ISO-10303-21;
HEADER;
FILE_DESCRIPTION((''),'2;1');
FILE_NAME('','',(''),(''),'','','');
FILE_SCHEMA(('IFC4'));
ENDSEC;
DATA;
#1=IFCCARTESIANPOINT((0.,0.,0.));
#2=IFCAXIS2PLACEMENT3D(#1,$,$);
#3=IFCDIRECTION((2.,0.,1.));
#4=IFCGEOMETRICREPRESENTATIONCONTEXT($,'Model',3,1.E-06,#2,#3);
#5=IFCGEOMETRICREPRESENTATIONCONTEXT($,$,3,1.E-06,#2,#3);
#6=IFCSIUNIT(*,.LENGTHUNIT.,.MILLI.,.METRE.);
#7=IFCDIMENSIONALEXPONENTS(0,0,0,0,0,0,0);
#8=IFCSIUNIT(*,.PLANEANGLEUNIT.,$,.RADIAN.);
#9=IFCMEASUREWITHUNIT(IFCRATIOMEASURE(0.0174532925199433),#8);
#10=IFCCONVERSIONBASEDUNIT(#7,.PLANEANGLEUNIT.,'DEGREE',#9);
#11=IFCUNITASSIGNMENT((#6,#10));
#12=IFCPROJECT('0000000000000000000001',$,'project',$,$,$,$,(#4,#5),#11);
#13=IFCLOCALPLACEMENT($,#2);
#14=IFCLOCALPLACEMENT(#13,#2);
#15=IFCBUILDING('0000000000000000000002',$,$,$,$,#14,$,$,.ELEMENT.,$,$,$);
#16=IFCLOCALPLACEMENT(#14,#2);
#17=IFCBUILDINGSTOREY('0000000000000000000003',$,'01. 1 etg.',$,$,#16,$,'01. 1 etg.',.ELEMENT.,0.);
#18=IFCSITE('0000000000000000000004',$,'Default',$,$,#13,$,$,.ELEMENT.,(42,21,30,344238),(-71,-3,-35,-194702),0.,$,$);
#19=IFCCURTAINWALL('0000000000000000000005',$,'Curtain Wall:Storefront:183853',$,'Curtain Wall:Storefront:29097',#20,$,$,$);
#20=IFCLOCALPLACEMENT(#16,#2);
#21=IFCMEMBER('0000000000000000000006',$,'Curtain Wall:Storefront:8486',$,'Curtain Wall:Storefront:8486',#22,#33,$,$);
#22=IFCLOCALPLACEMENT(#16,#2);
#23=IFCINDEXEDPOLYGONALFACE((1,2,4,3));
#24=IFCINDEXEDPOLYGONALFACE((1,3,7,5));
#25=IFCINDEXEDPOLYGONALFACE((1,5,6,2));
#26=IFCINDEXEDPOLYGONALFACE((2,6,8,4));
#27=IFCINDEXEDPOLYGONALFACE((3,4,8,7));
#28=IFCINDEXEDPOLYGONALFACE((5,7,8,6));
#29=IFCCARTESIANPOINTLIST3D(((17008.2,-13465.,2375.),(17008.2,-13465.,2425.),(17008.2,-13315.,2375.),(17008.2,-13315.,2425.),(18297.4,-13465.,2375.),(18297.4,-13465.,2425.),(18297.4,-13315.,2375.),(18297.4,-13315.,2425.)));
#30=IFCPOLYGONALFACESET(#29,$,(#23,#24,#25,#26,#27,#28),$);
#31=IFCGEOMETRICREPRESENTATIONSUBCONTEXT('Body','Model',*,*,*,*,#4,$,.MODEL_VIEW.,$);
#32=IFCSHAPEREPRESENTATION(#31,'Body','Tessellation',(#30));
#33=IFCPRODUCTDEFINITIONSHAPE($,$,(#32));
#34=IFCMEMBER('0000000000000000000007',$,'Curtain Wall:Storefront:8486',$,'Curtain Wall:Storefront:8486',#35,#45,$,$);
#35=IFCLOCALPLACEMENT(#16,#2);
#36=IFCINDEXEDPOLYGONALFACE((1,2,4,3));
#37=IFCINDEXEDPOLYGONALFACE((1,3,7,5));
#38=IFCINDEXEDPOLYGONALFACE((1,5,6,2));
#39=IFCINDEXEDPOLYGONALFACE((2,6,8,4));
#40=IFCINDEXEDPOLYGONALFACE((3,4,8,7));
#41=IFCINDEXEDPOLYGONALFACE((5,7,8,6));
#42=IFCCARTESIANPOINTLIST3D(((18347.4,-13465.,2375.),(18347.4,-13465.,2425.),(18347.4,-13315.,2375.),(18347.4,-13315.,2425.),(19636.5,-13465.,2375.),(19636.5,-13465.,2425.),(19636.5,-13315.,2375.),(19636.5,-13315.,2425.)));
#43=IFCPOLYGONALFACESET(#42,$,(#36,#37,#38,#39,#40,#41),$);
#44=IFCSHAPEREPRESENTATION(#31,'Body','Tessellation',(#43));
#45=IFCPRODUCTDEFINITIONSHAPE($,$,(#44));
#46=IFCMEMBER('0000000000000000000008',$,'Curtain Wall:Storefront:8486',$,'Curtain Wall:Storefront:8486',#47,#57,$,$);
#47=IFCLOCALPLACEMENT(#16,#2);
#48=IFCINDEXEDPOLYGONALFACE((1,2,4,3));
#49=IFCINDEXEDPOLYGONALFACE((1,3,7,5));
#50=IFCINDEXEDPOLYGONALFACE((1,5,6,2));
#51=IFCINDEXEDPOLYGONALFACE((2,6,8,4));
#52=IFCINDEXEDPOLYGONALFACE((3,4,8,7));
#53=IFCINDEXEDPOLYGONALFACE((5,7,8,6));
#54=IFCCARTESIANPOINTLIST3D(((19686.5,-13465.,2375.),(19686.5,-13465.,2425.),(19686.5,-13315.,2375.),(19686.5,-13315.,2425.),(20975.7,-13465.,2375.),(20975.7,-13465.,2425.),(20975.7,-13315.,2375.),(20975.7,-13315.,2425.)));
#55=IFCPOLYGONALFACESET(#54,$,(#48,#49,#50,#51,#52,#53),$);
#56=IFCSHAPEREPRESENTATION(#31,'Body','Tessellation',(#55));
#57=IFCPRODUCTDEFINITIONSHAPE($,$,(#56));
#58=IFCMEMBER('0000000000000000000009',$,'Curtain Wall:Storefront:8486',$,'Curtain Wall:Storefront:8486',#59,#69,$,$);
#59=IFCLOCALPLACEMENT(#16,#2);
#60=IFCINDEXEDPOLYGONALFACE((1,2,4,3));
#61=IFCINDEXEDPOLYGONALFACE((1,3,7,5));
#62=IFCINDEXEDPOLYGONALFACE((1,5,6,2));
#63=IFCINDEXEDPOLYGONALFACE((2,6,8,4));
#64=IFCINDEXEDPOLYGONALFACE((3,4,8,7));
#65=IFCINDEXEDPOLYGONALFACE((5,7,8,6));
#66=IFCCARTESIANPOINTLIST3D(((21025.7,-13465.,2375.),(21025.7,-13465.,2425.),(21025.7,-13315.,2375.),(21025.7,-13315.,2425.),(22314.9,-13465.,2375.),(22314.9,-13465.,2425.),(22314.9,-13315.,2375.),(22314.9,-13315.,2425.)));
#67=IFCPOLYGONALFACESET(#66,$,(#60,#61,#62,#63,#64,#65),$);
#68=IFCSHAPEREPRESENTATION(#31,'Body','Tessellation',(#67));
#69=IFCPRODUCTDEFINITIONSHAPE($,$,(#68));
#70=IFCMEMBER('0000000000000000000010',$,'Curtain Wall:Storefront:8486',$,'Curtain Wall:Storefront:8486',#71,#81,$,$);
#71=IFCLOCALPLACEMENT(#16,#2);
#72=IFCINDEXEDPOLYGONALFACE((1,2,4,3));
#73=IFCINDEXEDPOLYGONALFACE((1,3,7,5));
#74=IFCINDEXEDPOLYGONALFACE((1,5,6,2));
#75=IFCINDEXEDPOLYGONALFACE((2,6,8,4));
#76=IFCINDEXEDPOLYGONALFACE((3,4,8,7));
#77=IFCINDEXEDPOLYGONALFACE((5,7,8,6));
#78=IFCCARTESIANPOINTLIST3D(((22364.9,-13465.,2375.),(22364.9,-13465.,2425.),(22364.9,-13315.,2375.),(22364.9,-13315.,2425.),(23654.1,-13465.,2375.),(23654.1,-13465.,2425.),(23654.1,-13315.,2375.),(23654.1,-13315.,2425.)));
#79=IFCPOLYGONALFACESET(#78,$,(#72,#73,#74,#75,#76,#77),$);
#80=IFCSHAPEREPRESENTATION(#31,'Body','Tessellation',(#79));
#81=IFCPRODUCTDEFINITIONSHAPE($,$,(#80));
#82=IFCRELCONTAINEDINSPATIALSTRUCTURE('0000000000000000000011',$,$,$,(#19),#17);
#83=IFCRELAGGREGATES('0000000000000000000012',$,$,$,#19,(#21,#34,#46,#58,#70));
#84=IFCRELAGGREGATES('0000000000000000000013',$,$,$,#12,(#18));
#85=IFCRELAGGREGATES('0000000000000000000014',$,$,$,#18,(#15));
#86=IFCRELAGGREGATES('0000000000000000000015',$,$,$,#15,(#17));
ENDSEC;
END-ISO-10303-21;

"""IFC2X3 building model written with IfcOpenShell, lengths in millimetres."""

from ifc_helpers import new_model, entity, si_unit, converted_unit, direction, frame, frame_2d, origin, place, context, subcontext, project, spatial, rectangle, extrude, element, aggregate, save


model = new_model("IFC2X3")

# Units and contexts
model_context = context("Model", 3, precision=1e-06, world=origin(), true_north=direction((2.0, 0.0, 1.0)))
context_of_model = context(None, 3, precision=1e-06, world=origin(), true_north=direction((2.0, 0.0, 1.0)))
body_context = subcontext(model_context, "Body", "Model", "MODEL_VIEW")
ifc_project = project(units=[si_unit("LENGTHUNIT", "METRE", prefix="MILLI"), converted_unit("PLANEANGLEUNIT", "DEGREE", entity("IfcRatioMeasure", 0.0174532925199433), si_unit("PLANEANGLEUNIT", "RADIAN"), dimensions=[0, 0, 0, 0, 0, 0, 0])], contexts=[model_context, context_of_model])

# Site, building, storey
site_placement = place(None, origin())
site = spatial("IfcSite", under=ifc_project, at=site_placement, Name="Default", CompositionType="ELEMENT", RefLatitude=(42, 21, 30, 344238), RefLongitude=(-71, -3, -35, -194702), RefElevation=0.0)
building_placement = place(site_placement, origin())
building = spatial("IfcBuilding", under=site, at=building_placement, CompositionType="ELEMENT")
storey_placement = place(building_placement, origin())
storey = spatial("IfcBuildingStorey", under=building, at=storey_placement, Name="01. 1 etg.", LongName="01. 1 etg.", CompositionType="ELEMENT", Elevation=0.0)

# Curtain wall, members
curtain_wall_placement = place(storey_placement, origin())
curtain_wall = element("IfcCurtainWall", 1, at=curtain_wall_placement, inside=storey, Name="Curtain Wall:Storefront:183853", ObjectType="Curtain Wall:Storefront:29097")
member_1_placement = place(storey_placement, origin())
member_1 = element("IfcMember", 2, at=member_1_placement, Name="Curtain Wall:Storefront:8486", ObjectType="Curtain Wall:Storefront:8486", context=body_context, shape_type="SweptSolid", body=[
    extrude(rectangle(XDim=1289.2, YDim=150.0, at=frame_2d((0.0, 0.0), x_axis=(1.0, 0.0))), frame((17652.8, -13390.0, 2375.0), z_axis=(0.0, 0.0, 1.0), x_axis=(-1.0, 0.0, 0.0)), (0.0, 0.0, 1.0), 50.0),
])
member_2_placement = place(storey_placement, origin())
member_2 = element("IfcMember", 3, at=member_2_placement, Name="Curtain Wall:Storefront:8486", ObjectType="Curtain Wall:Storefront:8486", context=body_context, shape_type="SweptSolid", body=[
    extrude(rectangle(XDim=1289.2, YDim=150.0, at=frame_2d((0.0, 0.0), x_axis=(1.0, 0.0))), frame((18991.9, -13390.0, 2375.0), z_axis=(0.0, 0.0, 1.0), x_axis=(-1.0, 0.0, 0.0)), (0.0, 0.0, 1.0), 50.0),
])
member_3_placement = place(storey_placement, origin())
member_3 = element("IfcMember", 4, at=member_3_placement, Name="Curtain Wall:Storefront:8486", ObjectType="Curtain Wall:Storefront:8486", context=body_context, shape_type="SweptSolid", body=[
    extrude(rectangle(XDim=1289.2, YDim=150.0, at=frame_2d((0.0, 0.0), x_axis=(1.0, 0.0))), frame((20331.1, -13390.0, 2375.0), z_axis=(0.0, 0.0, 1.0), x_axis=(-1.0, 0.0, 0.0)), (0.0, 0.0, 1.0), 50.0),
])
member_4_placement = place(storey_placement, origin())
member_4 = element("IfcMember", 5, at=member_4_placement, Name="Curtain Wall:Storefront:8486", ObjectType="Curtain Wall:Storefront:8486", context=body_context, shape_type="SweptSolid", body=[
    extrude(rectangle(XDim=1289.2, YDim=150.0, at=frame_2d((0.0, 0.0), x_axis=(1.0, 0.0))), frame((21670.3, -13390.0, 2375.0), z_axis=(0.0, 0.0, 1.0), x_axis=(-1.0, 0.0, 0.0)), (0.0, 0.0, 1.0), 50.0),
])
member_5_placement = place(storey_placement, origin())
member_5 = element("IfcMember", 6, at=member_5_placement, Name="Curtain Wall:Storefront:8486", ObjectType="Curtain Wall:Storefront:8486", context=body_context, shape_type="SweptSolid", body=[
    extrude(rectangle(XDim=1289.2, YDim=150.0, at=frame_2d((0.0, 0.0), x_axis=(1.0, 0.0))), frame((23009.5, -13390.0, 2375.0), z_axis=(0.0, 0.0, 1.0), x_axis=(-1.0, 0.0, 0.0)), (0.0, 0.0, 1.0), 50.0),
])
aggregate(curtain_wall, [member_1, member_2, member_3, member_4, member_5])

save(model, "model.ifc")
